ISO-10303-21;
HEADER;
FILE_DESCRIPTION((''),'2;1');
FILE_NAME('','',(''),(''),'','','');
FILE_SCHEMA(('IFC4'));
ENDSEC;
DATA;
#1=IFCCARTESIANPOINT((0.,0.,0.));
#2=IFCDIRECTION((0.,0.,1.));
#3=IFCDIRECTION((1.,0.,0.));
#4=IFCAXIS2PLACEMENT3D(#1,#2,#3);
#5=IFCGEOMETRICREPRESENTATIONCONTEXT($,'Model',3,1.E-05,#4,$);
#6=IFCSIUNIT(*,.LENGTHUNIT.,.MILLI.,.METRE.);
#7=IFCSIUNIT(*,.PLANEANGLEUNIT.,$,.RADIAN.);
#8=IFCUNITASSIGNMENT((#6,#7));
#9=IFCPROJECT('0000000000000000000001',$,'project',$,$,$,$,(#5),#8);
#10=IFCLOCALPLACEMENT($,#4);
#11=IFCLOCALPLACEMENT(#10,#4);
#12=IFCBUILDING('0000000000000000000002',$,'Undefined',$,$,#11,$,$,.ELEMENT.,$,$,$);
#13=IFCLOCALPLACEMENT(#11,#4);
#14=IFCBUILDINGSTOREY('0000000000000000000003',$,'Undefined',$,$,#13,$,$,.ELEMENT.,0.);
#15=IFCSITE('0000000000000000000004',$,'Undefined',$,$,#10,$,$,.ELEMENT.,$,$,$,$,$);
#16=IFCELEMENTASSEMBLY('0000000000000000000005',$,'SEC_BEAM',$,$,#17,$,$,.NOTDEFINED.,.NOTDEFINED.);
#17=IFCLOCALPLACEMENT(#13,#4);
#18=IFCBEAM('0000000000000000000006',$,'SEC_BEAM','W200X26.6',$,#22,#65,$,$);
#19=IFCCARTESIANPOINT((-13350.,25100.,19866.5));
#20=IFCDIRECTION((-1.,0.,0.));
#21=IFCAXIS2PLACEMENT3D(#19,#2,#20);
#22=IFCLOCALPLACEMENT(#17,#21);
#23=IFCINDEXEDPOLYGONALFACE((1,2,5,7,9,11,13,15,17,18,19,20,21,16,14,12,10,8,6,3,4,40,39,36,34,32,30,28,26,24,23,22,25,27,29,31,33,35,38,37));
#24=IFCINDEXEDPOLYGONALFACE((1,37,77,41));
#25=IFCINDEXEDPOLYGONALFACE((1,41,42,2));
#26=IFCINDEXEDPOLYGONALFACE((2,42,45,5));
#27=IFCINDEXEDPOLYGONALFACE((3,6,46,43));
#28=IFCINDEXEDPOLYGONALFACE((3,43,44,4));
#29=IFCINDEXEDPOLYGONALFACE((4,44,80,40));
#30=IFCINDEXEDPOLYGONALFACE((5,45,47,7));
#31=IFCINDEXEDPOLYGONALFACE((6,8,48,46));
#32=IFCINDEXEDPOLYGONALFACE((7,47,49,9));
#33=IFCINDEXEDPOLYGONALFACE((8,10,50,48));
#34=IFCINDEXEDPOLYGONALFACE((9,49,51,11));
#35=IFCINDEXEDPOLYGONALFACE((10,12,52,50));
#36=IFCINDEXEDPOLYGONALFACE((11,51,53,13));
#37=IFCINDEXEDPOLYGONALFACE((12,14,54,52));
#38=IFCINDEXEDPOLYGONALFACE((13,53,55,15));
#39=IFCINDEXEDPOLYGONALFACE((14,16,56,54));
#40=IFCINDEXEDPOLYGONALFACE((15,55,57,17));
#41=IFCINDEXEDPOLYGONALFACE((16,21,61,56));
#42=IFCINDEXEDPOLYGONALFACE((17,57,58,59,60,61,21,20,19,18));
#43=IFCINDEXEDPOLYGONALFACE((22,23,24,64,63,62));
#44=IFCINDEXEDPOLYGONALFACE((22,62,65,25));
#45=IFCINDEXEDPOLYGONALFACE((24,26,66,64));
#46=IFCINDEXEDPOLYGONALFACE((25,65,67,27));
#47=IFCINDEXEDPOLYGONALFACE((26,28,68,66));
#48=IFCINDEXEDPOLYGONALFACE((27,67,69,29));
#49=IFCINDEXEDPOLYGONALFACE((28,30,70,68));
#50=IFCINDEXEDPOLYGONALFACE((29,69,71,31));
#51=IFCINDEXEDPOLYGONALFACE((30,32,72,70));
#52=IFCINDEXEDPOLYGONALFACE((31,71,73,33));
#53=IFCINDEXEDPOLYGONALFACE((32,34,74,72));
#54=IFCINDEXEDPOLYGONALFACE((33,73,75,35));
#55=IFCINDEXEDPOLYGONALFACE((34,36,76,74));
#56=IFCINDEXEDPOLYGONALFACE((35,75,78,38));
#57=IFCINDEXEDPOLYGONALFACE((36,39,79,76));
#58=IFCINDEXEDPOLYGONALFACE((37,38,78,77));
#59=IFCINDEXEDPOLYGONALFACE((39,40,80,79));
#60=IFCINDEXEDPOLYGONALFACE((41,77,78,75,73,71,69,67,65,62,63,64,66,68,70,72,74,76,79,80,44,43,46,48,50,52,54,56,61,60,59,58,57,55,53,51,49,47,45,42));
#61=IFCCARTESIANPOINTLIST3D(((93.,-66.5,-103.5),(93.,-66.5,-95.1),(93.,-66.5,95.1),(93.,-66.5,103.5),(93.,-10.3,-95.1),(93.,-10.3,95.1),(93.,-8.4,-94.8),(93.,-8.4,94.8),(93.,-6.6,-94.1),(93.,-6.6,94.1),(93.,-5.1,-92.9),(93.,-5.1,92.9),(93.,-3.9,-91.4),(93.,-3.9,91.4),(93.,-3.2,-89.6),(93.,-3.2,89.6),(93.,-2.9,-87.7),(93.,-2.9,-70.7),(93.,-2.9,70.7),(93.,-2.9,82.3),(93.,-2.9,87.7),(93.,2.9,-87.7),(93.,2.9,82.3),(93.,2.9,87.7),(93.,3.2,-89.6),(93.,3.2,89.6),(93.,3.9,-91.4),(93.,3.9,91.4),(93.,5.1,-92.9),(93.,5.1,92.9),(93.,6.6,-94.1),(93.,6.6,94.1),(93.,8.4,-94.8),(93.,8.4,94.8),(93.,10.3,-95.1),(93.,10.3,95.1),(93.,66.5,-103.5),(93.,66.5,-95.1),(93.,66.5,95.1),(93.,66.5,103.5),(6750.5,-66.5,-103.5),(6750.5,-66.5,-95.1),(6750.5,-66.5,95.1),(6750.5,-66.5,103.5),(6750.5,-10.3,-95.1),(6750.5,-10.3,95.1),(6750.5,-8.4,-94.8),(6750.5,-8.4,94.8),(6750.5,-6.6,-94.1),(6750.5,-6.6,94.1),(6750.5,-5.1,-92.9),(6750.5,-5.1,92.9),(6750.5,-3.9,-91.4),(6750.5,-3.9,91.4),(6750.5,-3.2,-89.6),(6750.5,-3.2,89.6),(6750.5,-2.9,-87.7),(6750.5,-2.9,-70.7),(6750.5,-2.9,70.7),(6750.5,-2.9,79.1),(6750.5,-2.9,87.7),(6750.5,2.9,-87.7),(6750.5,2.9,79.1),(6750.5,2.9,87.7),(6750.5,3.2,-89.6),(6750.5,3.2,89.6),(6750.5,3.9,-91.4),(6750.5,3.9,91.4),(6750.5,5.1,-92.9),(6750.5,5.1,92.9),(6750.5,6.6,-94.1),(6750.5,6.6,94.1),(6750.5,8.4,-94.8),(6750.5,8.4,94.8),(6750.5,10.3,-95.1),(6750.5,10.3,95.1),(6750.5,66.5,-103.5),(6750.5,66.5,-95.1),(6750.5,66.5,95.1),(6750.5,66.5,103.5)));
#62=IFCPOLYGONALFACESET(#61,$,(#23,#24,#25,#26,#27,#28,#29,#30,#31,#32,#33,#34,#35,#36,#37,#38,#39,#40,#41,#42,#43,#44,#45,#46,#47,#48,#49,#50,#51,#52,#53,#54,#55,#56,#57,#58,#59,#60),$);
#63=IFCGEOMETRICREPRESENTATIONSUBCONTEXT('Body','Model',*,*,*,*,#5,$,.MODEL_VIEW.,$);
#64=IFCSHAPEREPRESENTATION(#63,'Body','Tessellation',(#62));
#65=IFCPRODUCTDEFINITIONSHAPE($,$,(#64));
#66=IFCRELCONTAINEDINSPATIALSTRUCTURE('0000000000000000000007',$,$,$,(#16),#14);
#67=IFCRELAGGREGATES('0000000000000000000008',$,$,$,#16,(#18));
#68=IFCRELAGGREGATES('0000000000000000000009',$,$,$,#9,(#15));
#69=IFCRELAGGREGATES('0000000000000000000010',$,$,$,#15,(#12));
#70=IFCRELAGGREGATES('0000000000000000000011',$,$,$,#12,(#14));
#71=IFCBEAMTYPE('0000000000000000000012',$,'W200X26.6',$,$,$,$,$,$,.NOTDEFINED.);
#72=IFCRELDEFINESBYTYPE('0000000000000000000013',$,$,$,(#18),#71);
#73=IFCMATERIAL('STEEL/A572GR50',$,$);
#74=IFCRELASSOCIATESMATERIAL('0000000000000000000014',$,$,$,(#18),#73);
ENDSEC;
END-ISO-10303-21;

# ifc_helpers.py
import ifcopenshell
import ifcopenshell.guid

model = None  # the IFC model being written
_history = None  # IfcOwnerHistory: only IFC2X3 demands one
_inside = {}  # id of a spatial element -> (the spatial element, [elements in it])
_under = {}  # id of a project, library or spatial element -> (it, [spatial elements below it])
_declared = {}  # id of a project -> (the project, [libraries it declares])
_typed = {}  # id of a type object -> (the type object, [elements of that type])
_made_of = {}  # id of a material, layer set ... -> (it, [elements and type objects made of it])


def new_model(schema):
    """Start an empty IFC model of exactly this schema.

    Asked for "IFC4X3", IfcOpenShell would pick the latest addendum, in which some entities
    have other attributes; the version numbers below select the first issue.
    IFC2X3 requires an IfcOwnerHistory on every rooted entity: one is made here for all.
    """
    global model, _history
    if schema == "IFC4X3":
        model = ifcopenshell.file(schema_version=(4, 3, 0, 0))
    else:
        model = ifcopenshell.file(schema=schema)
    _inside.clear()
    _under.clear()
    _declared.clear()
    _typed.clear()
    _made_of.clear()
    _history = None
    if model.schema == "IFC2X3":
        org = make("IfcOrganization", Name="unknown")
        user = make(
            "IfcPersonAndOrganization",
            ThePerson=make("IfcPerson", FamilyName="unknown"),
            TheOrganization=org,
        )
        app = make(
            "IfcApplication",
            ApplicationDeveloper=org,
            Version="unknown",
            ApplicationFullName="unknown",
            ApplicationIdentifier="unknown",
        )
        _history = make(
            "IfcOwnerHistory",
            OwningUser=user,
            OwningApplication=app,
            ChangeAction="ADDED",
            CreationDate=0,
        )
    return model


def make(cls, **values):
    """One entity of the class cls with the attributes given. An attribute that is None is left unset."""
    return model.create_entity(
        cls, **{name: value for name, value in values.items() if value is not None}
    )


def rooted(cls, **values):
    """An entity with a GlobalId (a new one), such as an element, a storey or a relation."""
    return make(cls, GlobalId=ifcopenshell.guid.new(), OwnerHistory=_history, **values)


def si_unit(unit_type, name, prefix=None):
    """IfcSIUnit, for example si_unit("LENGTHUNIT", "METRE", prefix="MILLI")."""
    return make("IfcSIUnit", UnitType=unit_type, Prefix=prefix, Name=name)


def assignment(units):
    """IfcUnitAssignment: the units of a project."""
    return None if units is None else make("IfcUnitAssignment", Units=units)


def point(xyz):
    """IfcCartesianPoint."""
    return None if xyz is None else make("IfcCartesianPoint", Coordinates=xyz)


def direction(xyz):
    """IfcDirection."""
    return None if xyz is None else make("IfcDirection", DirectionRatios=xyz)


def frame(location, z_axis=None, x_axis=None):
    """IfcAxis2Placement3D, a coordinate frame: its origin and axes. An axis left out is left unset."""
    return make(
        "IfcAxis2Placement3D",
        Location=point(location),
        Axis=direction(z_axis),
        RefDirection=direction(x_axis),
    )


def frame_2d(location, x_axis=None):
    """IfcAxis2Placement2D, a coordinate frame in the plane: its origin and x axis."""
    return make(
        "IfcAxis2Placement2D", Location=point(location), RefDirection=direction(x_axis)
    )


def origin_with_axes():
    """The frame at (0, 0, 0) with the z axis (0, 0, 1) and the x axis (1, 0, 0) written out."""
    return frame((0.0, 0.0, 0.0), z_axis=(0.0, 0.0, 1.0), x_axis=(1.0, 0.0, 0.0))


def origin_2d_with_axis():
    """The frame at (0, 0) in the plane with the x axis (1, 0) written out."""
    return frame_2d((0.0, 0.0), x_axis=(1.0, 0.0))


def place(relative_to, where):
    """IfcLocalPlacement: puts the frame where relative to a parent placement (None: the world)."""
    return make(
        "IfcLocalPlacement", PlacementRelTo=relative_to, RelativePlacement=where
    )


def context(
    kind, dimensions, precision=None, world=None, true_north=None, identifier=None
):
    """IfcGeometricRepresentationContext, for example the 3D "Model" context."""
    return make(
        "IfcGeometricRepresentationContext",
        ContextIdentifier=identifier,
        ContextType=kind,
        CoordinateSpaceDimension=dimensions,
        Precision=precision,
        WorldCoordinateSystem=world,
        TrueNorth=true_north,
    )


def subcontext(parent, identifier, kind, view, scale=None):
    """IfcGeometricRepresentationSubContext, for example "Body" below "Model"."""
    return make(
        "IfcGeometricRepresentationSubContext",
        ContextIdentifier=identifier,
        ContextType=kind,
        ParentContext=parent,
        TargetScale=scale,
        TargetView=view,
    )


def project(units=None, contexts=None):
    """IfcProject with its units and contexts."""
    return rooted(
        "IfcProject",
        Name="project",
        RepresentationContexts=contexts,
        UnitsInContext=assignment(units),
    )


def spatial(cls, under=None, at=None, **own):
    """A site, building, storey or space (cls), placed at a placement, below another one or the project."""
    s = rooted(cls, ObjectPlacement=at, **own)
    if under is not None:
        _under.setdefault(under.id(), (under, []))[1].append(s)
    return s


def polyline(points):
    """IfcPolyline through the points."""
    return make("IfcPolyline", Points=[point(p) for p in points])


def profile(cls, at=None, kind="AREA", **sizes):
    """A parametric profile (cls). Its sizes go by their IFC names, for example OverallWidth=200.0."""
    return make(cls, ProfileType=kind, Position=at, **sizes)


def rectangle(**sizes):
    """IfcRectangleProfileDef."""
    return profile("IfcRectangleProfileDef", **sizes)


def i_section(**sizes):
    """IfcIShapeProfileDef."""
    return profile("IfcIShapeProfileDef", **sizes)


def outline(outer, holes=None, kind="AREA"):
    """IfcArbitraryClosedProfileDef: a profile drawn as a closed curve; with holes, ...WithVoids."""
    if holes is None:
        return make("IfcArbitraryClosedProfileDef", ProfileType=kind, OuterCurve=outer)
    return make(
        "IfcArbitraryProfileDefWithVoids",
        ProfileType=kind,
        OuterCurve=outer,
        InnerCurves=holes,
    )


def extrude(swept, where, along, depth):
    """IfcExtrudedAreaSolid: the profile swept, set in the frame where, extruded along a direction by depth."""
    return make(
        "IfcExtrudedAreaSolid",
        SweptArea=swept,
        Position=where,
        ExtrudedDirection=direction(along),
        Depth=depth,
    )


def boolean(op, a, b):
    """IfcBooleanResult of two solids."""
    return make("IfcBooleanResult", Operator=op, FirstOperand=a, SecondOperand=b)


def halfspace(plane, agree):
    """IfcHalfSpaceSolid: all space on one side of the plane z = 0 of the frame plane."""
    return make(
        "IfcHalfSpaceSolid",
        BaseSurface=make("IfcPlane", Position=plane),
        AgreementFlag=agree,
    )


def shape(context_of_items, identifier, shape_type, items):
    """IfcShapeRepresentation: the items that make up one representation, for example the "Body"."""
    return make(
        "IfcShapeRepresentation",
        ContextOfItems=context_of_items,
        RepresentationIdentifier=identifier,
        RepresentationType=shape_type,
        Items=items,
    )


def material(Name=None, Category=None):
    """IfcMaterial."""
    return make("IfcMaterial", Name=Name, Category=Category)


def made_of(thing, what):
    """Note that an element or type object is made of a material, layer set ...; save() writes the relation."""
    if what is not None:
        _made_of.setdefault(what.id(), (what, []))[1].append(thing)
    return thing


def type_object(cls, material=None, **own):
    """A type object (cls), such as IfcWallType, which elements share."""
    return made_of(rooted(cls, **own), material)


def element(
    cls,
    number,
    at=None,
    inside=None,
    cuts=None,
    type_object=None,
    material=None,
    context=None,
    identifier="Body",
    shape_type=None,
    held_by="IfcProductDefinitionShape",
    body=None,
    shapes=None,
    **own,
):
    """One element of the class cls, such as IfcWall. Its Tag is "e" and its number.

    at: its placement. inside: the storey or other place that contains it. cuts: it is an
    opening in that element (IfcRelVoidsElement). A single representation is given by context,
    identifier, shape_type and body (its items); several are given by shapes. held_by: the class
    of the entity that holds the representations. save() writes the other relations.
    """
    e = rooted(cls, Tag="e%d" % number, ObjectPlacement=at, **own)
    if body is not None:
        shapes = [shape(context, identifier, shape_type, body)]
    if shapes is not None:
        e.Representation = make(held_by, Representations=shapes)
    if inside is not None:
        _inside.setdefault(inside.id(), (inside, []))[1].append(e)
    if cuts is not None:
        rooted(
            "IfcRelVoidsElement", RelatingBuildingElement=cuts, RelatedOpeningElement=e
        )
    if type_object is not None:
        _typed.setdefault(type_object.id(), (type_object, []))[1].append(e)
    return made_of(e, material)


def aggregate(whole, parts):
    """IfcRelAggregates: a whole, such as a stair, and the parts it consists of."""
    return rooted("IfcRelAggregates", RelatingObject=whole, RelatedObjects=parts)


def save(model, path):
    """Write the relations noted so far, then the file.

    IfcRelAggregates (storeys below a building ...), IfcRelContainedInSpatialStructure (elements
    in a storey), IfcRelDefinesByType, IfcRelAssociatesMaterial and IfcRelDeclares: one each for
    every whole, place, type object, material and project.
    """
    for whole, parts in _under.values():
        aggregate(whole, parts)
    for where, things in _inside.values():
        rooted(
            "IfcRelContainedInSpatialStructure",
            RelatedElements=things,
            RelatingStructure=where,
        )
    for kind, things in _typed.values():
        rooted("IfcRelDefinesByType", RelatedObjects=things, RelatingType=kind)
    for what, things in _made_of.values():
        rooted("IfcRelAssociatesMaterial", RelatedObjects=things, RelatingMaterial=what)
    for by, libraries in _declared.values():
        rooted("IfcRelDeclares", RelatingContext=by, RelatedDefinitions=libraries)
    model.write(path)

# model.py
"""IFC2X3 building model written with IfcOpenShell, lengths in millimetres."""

from ifc_helpers import new_model, si_unit, frame, origin_with_axes, origin_2d_with_axis, place, context, subcontext, project, spatial, polyline, rectangle, i_section, outline, extrude, boolean, halfspace, material, type_object, element, aggregate, save


model = new_model("IFC2X3")

# Units and contexts
model_context = context("Model", 3, precision=1e-05, world=origin_with_axes())
body_context = subcontext(model_context, "Body", "Model", "MODEL_VIEW")
ifc_project = project(units=[si_unit("LENGTHUNIT", "METRE", prefix="MILLI"), si_unit("PLANEANGLEUNIT", "RADIAN")], contexts=[model_context])

# Site, building, storey
site_placement = place(None, origin_with_axes())
site = spatial("IfcSite", under=ifc_project, at=site_placement, Name="Undefined", CompositionType="ELEMENT")
building_placement = place(site_placement, origin_with_axes())
building = spatial("IfcBuilding", under=site, at=building_placement, Name="Undefined", CompositionType="ELEMENT")
storey_placement = place(building_placement, origin_with_axes())
storey = spatial("IfcBuildingStorey", under=building, at=storey_placement, Name="Undefined", CompositionType="ELEMENT", Elevation=0.0)

# Shared definitions
ifc_material_1 = material(Name="STEEL/A572GR50")

# Element assembly, beam
beam_type_1 = type_object("IfcBeamType", Name="W200X26.6", PredefinedType="NOTDEFINED")
assembly_1_placement = place(storey_placement, origin_with_axes())
assembly_1 = element("IfcElementAssembly", 1, at=assembly_1_placement, inside=storey, Name="SEC_BEAM", AssemblyPlace="NOTDEFINED", PredefinedType="NOTDEFINED")
beam_1_placement = place(assembly_1_placement, frame((-13350.0, 25100.0, 19866.5), z_axis=(0.0, 0.0, 1.0), x_axis=(-1.0, 0.0, 0.0)))
beam_1 = element("IfcBeam", 2, at=beam_1_placement, type_object=beam_type_1, material=ifc_material_1, Name="SEC_BEAM", Description="W200X26.6", context=body_context, shape_type="CSG", body=[
    boolean("DIFFERENCE", boolean("DIFFERENCE", boolean("DIFFERENCE", boolean("DIFFERENCE", boolean("DIFFERENCE", boolean("DIFFERENCE", extrude(i_section(OverallWidth=133.0, OverallDepth=207.0, WebThickness=5.8, FlangeThickness=8.4, FilletRadius=7.4, at=origin_2d_with_axis()), frame((6850.0, 0.0, 0.0), z_axis=(-1.0, 0.0, 0.0), x_axis=(0.0, -1.0, 0.0)), (0.0, 0.0, 1.0), 6850.0), extrude(outline(polyline([(0.0, 0.0), (10.0, 0.0), (10.0, 31.2), (0.0, 31.2), (0.0, 0.0)])), frame((83.0, 76.5, 82.3), z_axis=(0.0, -1.0, 0.0), x_axis=(1.0, 0.0, 0.0)), (0.0, 0.0, 1.0), 153.0)), extrude(rectangle(XDim=159.7, YDim=159.7, at=origin_2d_with_axis()), frame((83.1, -82.8, 70.7), z_axis=(0.0, 0.0, -1.0), x_axis=(1.0, 0.0, 0.0)), (0.0, 0.0, 1.0), 141.5)), extrude(outline(polyline([(0.0, 0.0), (34.4, 0.0), (34.4, 10.0), (0.0, 10.0), (0.0, 0.0)])), frame((6750.5, -76.5, 79.1), z_axis=(0.0, 1.0, 0.0), x_axis=(0.0, 0.0, 1.0)), (0.0, 0.0, 1.0), 153.0)), extrude(rectangle(XDim=165.1, YDim=165.1, at=origin_2d_with_axis()), frame((6763.0, -85.5, 70.7), z_axis=(0.0, 0.0, -1.0), x_axis=(-1.0, 0.0, 0.0)), (0.0, 0.0, 1.0), 141.5)), halfspace(frame((6750.5, 0.0, 203.5), z_axis=(1.0, 0.0, 0.0), x_axis=(0.0, 1.0, 0.0)), False)), halfspace(frame((93.0, 0.0, 203.5), z_axis=(-1.0, 0.0, 0.0), x_axis=(0.0, -1.0, 0.0)), False)),
])

aggregate(assembly_1, [beam_1])

save(model, "model.ifc")
